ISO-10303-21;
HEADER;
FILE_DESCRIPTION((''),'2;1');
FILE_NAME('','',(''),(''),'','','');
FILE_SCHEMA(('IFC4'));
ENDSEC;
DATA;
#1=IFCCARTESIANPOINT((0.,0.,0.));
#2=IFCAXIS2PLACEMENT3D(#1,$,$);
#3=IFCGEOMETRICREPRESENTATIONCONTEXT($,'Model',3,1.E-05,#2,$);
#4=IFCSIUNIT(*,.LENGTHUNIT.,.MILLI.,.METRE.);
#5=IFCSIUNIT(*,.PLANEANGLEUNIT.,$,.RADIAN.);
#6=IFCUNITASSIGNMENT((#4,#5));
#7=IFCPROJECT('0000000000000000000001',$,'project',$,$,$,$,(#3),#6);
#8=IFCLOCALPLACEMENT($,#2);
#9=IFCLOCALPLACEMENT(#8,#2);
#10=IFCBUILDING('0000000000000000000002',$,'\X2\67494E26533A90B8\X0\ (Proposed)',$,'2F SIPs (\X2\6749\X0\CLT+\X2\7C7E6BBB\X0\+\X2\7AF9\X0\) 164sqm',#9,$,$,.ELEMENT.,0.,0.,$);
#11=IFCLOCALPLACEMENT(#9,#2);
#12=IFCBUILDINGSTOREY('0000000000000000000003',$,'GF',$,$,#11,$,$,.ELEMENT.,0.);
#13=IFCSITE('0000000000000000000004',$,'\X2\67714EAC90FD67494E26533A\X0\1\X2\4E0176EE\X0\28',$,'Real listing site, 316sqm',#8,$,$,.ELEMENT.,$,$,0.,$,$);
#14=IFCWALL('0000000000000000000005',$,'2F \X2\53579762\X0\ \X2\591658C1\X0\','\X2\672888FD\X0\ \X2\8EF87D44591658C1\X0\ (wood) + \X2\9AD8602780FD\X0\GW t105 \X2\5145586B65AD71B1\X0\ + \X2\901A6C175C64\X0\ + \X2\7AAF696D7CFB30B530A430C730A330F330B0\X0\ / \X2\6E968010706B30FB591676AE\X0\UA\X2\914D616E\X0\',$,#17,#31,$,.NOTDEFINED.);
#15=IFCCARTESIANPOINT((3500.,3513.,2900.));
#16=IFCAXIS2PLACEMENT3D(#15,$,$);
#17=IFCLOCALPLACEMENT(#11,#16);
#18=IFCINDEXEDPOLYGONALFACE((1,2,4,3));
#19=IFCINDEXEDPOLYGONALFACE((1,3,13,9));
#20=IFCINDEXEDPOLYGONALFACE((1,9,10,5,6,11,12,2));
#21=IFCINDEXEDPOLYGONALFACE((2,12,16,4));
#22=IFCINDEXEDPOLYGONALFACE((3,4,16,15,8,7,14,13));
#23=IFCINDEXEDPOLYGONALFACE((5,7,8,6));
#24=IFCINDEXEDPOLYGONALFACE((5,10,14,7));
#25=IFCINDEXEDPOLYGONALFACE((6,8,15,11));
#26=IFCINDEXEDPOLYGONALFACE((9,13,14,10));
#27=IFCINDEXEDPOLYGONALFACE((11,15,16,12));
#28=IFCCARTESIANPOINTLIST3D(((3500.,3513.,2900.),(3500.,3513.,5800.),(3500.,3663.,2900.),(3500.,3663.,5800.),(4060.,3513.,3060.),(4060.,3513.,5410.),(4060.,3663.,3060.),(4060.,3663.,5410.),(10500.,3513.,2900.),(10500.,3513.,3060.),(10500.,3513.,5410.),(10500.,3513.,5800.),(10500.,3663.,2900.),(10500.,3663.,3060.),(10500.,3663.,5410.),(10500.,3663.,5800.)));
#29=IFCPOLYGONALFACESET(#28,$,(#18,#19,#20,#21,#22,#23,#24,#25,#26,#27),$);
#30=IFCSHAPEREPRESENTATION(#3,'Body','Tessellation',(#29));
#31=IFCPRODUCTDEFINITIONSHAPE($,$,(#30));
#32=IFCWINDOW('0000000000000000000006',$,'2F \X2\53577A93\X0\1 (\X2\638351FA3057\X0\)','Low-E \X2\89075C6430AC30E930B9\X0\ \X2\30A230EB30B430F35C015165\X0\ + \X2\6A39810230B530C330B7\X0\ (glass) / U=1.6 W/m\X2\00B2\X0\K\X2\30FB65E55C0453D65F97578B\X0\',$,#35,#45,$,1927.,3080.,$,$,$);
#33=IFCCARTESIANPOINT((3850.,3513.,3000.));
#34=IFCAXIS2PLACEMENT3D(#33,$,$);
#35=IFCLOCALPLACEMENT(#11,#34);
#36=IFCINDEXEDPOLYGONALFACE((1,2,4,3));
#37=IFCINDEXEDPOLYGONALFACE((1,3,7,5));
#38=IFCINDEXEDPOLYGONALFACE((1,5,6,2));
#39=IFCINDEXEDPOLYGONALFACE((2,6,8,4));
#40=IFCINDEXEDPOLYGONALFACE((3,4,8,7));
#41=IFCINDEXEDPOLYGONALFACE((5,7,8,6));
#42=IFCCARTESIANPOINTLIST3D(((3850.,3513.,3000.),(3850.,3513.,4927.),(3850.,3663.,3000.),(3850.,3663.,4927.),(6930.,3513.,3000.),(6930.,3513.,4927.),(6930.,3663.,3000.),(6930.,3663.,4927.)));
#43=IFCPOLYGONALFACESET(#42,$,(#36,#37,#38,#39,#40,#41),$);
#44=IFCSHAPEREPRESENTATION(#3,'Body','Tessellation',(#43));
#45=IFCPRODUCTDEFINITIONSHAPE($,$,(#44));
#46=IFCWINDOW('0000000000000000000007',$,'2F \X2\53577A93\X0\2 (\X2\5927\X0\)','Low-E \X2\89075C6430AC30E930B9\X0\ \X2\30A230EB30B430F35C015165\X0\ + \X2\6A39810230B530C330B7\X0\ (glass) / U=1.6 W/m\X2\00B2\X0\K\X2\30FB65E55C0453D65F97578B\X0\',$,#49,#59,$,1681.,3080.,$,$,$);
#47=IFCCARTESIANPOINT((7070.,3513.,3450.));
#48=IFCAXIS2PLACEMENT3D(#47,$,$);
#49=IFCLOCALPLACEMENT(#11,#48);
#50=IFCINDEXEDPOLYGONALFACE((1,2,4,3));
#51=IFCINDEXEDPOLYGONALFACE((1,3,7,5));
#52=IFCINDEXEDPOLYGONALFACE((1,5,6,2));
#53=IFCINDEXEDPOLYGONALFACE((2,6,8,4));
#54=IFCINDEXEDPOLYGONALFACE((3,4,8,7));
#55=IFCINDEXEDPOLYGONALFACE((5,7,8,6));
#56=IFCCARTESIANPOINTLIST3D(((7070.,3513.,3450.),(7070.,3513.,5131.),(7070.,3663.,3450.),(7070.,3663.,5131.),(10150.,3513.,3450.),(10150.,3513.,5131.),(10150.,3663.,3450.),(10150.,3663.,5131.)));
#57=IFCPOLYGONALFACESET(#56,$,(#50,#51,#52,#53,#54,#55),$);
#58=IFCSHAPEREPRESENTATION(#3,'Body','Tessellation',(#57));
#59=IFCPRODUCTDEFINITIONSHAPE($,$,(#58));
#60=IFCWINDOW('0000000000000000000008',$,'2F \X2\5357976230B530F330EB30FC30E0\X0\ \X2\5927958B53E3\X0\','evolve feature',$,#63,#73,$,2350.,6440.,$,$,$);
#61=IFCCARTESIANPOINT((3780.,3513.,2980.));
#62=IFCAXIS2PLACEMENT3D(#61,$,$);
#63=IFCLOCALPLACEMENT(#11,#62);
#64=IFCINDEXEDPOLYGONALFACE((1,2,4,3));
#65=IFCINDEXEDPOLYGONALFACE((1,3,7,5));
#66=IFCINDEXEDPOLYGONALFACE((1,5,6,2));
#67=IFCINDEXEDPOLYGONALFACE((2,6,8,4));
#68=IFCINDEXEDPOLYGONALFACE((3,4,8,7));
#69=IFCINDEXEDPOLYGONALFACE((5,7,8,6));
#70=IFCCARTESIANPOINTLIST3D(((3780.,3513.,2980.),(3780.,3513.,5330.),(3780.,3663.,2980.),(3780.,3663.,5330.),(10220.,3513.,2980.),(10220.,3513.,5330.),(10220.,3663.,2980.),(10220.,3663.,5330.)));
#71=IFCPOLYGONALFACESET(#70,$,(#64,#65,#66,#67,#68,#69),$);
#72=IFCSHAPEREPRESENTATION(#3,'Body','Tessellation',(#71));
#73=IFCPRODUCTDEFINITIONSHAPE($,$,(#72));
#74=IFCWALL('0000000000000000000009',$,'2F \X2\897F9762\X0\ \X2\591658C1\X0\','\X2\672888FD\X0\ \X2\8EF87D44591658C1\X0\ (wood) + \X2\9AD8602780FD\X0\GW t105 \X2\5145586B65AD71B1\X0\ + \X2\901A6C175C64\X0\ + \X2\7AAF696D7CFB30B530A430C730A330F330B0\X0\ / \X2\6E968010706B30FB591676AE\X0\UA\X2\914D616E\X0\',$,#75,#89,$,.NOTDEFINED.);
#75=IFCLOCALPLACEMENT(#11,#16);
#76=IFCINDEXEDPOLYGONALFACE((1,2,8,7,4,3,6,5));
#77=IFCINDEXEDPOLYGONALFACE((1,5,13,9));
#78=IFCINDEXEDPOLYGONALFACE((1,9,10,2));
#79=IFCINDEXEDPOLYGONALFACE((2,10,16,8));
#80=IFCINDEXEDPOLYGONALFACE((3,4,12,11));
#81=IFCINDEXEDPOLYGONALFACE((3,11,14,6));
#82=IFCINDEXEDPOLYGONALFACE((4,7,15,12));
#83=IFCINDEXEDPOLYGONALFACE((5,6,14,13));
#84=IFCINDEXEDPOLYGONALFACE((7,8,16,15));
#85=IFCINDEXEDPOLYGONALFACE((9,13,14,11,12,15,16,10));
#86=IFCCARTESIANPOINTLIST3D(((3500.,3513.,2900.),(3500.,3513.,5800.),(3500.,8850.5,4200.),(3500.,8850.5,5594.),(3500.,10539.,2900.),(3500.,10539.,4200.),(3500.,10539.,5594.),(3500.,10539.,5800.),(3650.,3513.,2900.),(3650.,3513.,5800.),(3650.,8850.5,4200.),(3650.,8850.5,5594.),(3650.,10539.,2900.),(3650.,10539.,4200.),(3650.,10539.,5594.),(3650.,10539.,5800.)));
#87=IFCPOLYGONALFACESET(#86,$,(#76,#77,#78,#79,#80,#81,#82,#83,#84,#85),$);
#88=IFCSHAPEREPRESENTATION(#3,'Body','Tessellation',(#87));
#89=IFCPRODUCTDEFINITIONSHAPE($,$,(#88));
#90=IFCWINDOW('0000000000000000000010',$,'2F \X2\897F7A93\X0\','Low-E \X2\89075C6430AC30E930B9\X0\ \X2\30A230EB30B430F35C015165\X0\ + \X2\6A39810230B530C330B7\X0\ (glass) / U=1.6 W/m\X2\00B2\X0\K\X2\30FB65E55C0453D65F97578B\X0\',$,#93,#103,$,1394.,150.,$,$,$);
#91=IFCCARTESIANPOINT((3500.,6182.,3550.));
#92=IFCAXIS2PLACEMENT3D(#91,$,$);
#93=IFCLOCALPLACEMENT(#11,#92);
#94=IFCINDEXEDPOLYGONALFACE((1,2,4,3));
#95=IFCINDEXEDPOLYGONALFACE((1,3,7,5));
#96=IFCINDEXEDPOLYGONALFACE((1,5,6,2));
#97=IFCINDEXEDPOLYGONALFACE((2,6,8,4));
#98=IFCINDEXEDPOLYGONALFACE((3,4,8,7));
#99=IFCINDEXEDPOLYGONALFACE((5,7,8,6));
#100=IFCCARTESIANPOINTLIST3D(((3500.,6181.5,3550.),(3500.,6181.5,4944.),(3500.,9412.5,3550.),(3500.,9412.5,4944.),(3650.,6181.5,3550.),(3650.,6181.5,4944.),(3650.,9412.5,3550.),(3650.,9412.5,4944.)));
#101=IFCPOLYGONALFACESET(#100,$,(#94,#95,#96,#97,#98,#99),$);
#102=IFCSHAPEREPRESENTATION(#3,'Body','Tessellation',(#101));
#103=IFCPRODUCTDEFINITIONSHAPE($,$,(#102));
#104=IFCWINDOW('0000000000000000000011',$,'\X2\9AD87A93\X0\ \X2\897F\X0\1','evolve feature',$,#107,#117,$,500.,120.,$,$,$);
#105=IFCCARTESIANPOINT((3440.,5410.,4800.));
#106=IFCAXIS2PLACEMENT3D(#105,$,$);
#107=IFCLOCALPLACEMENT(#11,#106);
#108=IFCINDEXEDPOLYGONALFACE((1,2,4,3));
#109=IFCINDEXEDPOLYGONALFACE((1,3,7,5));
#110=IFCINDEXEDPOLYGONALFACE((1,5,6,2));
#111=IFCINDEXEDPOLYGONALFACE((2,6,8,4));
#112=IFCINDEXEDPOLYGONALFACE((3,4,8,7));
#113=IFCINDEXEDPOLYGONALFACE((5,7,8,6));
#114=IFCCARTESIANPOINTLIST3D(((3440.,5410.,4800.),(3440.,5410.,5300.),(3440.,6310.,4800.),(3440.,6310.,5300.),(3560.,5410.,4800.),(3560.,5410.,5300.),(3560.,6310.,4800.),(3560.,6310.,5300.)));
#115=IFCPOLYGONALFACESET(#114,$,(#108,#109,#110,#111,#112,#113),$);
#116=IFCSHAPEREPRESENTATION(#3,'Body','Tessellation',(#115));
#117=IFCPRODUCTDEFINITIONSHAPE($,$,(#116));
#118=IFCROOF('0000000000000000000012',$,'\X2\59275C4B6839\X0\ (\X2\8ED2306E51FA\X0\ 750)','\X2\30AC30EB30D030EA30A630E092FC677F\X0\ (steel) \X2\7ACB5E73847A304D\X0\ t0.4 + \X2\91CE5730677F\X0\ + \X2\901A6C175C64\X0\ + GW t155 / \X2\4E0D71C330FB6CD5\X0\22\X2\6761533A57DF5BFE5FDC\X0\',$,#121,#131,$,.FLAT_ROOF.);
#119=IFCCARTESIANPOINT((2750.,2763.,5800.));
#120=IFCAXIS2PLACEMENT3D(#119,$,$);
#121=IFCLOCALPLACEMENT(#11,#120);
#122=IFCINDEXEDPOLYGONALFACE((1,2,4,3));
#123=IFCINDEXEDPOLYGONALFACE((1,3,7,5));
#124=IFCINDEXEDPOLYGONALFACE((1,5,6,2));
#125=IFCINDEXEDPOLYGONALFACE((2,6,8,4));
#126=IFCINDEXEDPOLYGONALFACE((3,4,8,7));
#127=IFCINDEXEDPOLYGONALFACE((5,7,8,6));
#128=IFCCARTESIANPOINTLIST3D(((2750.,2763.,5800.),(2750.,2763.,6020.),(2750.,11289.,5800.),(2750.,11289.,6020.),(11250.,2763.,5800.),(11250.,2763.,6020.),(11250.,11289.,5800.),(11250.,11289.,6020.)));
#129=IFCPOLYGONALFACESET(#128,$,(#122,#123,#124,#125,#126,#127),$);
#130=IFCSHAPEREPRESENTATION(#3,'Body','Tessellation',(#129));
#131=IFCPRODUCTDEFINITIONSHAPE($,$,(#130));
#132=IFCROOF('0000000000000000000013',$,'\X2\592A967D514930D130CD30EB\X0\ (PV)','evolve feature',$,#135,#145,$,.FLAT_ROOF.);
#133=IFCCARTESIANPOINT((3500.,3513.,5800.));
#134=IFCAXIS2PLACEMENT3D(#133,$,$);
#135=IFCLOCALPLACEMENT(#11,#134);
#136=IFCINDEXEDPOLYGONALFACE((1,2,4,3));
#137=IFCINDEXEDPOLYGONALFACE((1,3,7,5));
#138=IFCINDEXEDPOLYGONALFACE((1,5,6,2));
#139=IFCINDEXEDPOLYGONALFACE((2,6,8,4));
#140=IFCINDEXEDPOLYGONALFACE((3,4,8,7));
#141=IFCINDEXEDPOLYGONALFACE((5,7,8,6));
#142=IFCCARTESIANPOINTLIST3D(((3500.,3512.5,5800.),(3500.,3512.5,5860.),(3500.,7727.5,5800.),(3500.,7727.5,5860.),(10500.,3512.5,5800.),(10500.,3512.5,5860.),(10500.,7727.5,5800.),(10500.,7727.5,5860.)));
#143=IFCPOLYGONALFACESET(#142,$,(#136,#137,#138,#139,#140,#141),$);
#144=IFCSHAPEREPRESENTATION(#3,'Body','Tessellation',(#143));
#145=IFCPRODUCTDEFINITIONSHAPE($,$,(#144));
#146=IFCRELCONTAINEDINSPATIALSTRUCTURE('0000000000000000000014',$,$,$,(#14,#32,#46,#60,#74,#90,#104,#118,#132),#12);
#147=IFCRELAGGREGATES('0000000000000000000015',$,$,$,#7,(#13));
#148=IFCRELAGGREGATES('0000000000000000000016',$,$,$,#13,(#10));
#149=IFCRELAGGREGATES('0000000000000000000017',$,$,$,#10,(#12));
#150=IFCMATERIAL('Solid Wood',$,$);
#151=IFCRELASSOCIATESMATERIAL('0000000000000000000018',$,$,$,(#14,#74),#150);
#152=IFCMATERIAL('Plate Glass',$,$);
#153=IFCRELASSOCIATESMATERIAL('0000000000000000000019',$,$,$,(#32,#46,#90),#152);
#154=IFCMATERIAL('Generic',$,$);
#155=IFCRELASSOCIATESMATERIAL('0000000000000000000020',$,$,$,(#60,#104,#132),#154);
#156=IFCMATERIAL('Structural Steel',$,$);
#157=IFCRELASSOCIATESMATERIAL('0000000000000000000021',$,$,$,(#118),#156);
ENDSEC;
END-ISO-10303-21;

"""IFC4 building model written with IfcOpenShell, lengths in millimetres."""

from ifc_helpers import new_model, si_unit, frame, frame_2d, origin, place, context, project, spatial, rectangle, extrude, material, element, fill, save


model = new_model("IFC4")

# Units and contexts
model_context = context("Model", 3, precision=1e-05, world=origin())
ifc_project = project(units=[si_unit("LENGTHUNIT", "METRE", prefix="MILLI"), si_unit("PLANEANGLEUNIT", "RADIAN")], contexts=[model_context])

# Site, building, storey
site_placement = place(None, origin())
site = spatial("IfcSite", under=ifc_project, at=site_placement, Name="東京都杉並区1丁目28", ObjectType="Real listing site, 316sqm", CompositionType="ELEMENT", RefElevation=0.0)
building_placement = place(site_placement, origin())
building = spatial("IfcBuilding", under=site, at=building_placement, Name="杉並区邸 (Proposed)", ObjectType="2F SIPs (杉CLT+籾殻+竹) 164sqm", CompositionType="ELEMENT", ElevationOfRefHeight=0.0, ElevationOfTerrain=0.0)
storey_placement = place(building_placement, origin())
storey = spatial("IfcBuildingStorey", under=building, at=storey_placement, Name="GF", CompositionType="ELEMENT", Elevation=0.0)

# Shared definitions
ifc_material_1 = material(Name="Solid Wood")
ifc_material_2 = material(Name="Generic")

# Shared definitions
ifc_material_3 = material(Name="Plate Glass")

# Walls, openings, windows
wall_1_placement = place(storey_placement, frame((3500.0, 3513.0, 2900.0)))
wall_1 = element("IfcWall", 1, at=wall_1_placement, inside=storey, material=ifc_material_1, Name="2F 南面 外壁", Description="木製 軸組外壁 (wood) + 高性能GW t105 充填断熱 + 通気層 + 窯業系サイディング / 準耐火・外皮UA配慮", PredefinedType="NOTDEFINED", context=model_context, shape_type="SweptSolid", body=[
    extrude(rectangle(XDim=7000.0, YDim=150.0, at=frame_2d((3500.0, 75.0))), frame((3500.0, 3513.0, 2900.0)), (0.0, 0.0, 1.0), 2900.0),
])
opening_1_placement = place(storey_placement, frame((3850.0, 3513.0, 3000.0)))
opening_1 = element("IfcOpeningElement", 2, at=opening_1_placement, cuts=wall_1, PredefinedType="NOTDEFINED", context=model_context, shape_type="SweptSolid", body=[
    extrude(rectangle(XDim=3080.0, YDim=150.0, at=frame_2d((1540.0, 75.0))), frame((3850.0, 3513.0, 3000.0)), (0.0, 0.0, 1.0), 1927.0),
])
opening_2_placement = place(storey_placement, frame((7070.0, 3513.0, 3450.0)))
opening_2 = element("IfcOpeningElement", 3, at=opening_2_placement, cuts=wall_1, PredefinedType="NOTDEFINED", context=model_context, shape_type="SweptSolid", body=[
    extrude(rectangle(XDim=3080.0, YDim=150.0, at=frame_2d((1540.0, 75.0))), frame((7070.0, 3513.0, 3450.0)), (0.0, 0.0, 1.0), 1681.0),
])
opening_3_placement = place(storey_placement, frame((3780.0, 3513.0, 2980.0)))
opening_3 = element("IfcOpeningElement", 4, at=opening_3_placement, cuts=wall_1, PredefinedType="NOTDEFINED", context=model_context, shape_type="SweptSolid", body=[
    extrude(rectangle(XDim=6440.0, YDim=150.0, at=frame_2d((3220.0, 75.0))), frame((3780.0, 3513.0, 2980.0)), (0.0, 0.0, 1.0), 2350.0),
])
window_1_placement = place(storey_placement, frame((3850.0, 3513.0, 3000.0)))
window_1 = element("IfcWindow", 5, at=window_1_placement, inside=storey, material=ifc_material_3, Name="2F 南窓1 (掃出し)", Description="Low-E 複層ガラス アルゴン封入 + 樹脂サッシ (glass) / U=1.6 W/m²K・日射取得型", OverallHeight=1927.0, OverallWidth=3080.0, context=model_context, shape_type="SweptSolid", body=[
    extrude(rectangle(XDim=3080.0, YDim=150.0, at=frame_2d((1540.0, 75.0))), frame((3850.0, 3513.0, 3000.0)), (0.0, 0.0, 1.0), 1927.0),
])
fill(opening_1, window_1)
window_2_placement = place(storey_placement, frame((7070.0, 3513.0, 3450.0)))
window_2 = element("IfcWindow", 6, at=window_2_placement, inside=storey, material=ifc_material_3, Name="2F 南窓2 (大)", Description="Low-E 複層ガラス アルゴン封入 + 樹脂サッシ (glass) / U=1.6 W/m²K・日射取得型", OverallHeight=1681.0, OverallWidth=3080.0, context=model_context, shape_type="SweptSolid", body=[
    extrude(rectangle(XDim=3080.0, YDim=150.0, at=frame_2d((1540.0, 75.0))), frame((7070.0, 3513.0, 3450.0)), (0.0, 0.0, 1.0), 1681.0),
])
fill(opening_2, window_2)
window_3_placement = place(storey_placement, frame((3780.0, 3513.0, 2980.0)))
window_3 = element("IfcWindow", 7, at=window_3_placement, inside=storey, material=ifc_material_2, Name="2F 南面サンルーム 大開口", Description="evolve feature", OverallHeight=2350.0, OverallWidth=6440.0, context=model_context, shape_type="SweptSolid", body=[
    extrude(rectangle(XDim=6440.0, YDim=150.0, at=frame_2d((3220.0, 75.0))), frame((3780.0, 3513.0, 2980.0)), (0.0, 0.0, 1.0), 2350.0),
])
fill(opening_3, window_3)
wall_2_placement = place(storey_placement, frame((3500.0, 3513.0, 2900.0)))
wall_2 = element("IfcWall", 8, at=wall_2_placement, inside=storey, material=ifc_material_1, Name="2F 西面 外壁", Description="木製 軸組外壁 (wood) + 高性能GW t105 充填断熱 + 通気層 + 窯業系サイディング / 準耐火・外皮UA配慮", PredefinedType="NOTDEFINED", context=model_context, shape_type="SweptSolid", body=[
    extrude(rectangle(XDim=150.0, YDim=7026.0, at=frame_2d((75.0, 3513.0))), frame((3500.0, 3513.0, 2900.0)), (0.0, 0.0, 1.0), 2900.0),
])
opening_4_placement = place(storey_placement, frame((3500.0, 6182.0, 3550.0)))
opening_4 = element("IfcOpeningElement", 9, at=opening_4_placement, cuts=wall_2, PredefinedType="NOTDEFINED", context=model_context, shape_type="SweptSolid", body=[
    extrude(rectangle(XDim=150.0, YDim=3231.0, at=frame_2d((75.0, 1615.0))), frame((3500.0, 6182.0, 3550.0)), (0.0, 0.0, 1.0), 1394.0),
])
opening_5_placement = place(storey_placement, frame((3440.0, 5410.0, 4800.0)))
opening_5 = element("IfcOpeningElement", 10, at=opening_5_placement, cuts=wall_2, PredefinedType="NOTDEFINED", context=model_context, shape_type="SweptSolid", body=[
    extrude(rectangle(XDim=120.0, YDim=900.0, at=frame_2d((60.0, 450.0))), frame((3440.0, 5410.0, 4800.0)), (0.0, 0.0, 1.0), 500.0),
])
window_4_placement = place(storey_placement, frame((3500.0, 6182.0, 3550.0)))
window_4 = element("IfcWindow", 11, at=window_4_placement, inside=storey, material=ifc_material_3, Name="2F 西窓", Description="Low-E 複層ガラス アルゴン封入 + 樹脂サッシ (glass) / U=1.6 W/m²K・日射取得型", OverallHeight=1394.0, OverallWidth=150.0, context=model_context, shape_type="SweptSolid", body=[
    extrude(rectangle(XDim=150.0, YDim=3231.0, at=frame_2d((75.0, 1615.0))), frame((3500.0, 6182.0, 3550.0)), (0.0, 0.0, 1.0), 1394.0),
])
fill(opening_4, window_4)
window_5_placement = place(storey_placement, frame((3440.0, 5410.0, 4800.0)))
window_5 = element("IfcWindow", 12, at=window_5_placement, inside=storey, material=ifc_material_2, Name="高窓 西1", Description="evolve feature", OverallHeight=500.0, OverallWidth=120.0, context=model_context, shape_type="SweptSolid", body=[
    extrude(rectangle(XDim=120.0, YDim=900.0, at=frame_2d((60.0, 450.0))), frame((3440.0, 5410.0, 4800.0)), (0.0, 0.0, 1.0), 500.0),
])
fill(opening_5, window_5)

# Roofs
ifc_material_4 = material(Name="Structural Steel")
roof_1_placement = place(storey_placement, frame((2750.0, 2763.0, 5800.0)))
element("IfcRoof", 13, at=roof_1_placement, inside=storey, material=ifc_material_4, Name="大屋根 (軒の出 750)", Description="ガルバリウム鋼板 (steel) 立平葺き t0.4 + 野地板 + 通気層 + GW t155 / 不燃・法22条区域対応", PredefinedType="FLAT_ROOF", context=model_context, shape_type="SweptSolid", body=[
    extrude(rectangle(XDim=8500.0, YDim=8526.0, at=frame_2d((4250.0, 4263.0))), frame((2750.0, 2763.0, 5800.0)), (0.0, 0.0, 1.0), 220.0),
])
roof_2_placement = place(storey_placement, frame((3500.0, 3513.0, 5800.0)))
element("IfcRoof", 14, at=roof_2_placement, inside=storey, material=ifc_material_2, Name="太陽光パネル (PV)", Description="evolve feature", PredefinedType="FLAT_ROOF", context=model_context, shape_type="SweptSolid", body=[
    extrude(rectangle(XDim=7000.0, YDim=4215.0, at=frame_2d((3500.0, 2107.0))), frame((3500.0, 3513.0, 5800.0)), (0.0, 0.0, 1.0), 60.0),
])

save(model, "model.ifc")
